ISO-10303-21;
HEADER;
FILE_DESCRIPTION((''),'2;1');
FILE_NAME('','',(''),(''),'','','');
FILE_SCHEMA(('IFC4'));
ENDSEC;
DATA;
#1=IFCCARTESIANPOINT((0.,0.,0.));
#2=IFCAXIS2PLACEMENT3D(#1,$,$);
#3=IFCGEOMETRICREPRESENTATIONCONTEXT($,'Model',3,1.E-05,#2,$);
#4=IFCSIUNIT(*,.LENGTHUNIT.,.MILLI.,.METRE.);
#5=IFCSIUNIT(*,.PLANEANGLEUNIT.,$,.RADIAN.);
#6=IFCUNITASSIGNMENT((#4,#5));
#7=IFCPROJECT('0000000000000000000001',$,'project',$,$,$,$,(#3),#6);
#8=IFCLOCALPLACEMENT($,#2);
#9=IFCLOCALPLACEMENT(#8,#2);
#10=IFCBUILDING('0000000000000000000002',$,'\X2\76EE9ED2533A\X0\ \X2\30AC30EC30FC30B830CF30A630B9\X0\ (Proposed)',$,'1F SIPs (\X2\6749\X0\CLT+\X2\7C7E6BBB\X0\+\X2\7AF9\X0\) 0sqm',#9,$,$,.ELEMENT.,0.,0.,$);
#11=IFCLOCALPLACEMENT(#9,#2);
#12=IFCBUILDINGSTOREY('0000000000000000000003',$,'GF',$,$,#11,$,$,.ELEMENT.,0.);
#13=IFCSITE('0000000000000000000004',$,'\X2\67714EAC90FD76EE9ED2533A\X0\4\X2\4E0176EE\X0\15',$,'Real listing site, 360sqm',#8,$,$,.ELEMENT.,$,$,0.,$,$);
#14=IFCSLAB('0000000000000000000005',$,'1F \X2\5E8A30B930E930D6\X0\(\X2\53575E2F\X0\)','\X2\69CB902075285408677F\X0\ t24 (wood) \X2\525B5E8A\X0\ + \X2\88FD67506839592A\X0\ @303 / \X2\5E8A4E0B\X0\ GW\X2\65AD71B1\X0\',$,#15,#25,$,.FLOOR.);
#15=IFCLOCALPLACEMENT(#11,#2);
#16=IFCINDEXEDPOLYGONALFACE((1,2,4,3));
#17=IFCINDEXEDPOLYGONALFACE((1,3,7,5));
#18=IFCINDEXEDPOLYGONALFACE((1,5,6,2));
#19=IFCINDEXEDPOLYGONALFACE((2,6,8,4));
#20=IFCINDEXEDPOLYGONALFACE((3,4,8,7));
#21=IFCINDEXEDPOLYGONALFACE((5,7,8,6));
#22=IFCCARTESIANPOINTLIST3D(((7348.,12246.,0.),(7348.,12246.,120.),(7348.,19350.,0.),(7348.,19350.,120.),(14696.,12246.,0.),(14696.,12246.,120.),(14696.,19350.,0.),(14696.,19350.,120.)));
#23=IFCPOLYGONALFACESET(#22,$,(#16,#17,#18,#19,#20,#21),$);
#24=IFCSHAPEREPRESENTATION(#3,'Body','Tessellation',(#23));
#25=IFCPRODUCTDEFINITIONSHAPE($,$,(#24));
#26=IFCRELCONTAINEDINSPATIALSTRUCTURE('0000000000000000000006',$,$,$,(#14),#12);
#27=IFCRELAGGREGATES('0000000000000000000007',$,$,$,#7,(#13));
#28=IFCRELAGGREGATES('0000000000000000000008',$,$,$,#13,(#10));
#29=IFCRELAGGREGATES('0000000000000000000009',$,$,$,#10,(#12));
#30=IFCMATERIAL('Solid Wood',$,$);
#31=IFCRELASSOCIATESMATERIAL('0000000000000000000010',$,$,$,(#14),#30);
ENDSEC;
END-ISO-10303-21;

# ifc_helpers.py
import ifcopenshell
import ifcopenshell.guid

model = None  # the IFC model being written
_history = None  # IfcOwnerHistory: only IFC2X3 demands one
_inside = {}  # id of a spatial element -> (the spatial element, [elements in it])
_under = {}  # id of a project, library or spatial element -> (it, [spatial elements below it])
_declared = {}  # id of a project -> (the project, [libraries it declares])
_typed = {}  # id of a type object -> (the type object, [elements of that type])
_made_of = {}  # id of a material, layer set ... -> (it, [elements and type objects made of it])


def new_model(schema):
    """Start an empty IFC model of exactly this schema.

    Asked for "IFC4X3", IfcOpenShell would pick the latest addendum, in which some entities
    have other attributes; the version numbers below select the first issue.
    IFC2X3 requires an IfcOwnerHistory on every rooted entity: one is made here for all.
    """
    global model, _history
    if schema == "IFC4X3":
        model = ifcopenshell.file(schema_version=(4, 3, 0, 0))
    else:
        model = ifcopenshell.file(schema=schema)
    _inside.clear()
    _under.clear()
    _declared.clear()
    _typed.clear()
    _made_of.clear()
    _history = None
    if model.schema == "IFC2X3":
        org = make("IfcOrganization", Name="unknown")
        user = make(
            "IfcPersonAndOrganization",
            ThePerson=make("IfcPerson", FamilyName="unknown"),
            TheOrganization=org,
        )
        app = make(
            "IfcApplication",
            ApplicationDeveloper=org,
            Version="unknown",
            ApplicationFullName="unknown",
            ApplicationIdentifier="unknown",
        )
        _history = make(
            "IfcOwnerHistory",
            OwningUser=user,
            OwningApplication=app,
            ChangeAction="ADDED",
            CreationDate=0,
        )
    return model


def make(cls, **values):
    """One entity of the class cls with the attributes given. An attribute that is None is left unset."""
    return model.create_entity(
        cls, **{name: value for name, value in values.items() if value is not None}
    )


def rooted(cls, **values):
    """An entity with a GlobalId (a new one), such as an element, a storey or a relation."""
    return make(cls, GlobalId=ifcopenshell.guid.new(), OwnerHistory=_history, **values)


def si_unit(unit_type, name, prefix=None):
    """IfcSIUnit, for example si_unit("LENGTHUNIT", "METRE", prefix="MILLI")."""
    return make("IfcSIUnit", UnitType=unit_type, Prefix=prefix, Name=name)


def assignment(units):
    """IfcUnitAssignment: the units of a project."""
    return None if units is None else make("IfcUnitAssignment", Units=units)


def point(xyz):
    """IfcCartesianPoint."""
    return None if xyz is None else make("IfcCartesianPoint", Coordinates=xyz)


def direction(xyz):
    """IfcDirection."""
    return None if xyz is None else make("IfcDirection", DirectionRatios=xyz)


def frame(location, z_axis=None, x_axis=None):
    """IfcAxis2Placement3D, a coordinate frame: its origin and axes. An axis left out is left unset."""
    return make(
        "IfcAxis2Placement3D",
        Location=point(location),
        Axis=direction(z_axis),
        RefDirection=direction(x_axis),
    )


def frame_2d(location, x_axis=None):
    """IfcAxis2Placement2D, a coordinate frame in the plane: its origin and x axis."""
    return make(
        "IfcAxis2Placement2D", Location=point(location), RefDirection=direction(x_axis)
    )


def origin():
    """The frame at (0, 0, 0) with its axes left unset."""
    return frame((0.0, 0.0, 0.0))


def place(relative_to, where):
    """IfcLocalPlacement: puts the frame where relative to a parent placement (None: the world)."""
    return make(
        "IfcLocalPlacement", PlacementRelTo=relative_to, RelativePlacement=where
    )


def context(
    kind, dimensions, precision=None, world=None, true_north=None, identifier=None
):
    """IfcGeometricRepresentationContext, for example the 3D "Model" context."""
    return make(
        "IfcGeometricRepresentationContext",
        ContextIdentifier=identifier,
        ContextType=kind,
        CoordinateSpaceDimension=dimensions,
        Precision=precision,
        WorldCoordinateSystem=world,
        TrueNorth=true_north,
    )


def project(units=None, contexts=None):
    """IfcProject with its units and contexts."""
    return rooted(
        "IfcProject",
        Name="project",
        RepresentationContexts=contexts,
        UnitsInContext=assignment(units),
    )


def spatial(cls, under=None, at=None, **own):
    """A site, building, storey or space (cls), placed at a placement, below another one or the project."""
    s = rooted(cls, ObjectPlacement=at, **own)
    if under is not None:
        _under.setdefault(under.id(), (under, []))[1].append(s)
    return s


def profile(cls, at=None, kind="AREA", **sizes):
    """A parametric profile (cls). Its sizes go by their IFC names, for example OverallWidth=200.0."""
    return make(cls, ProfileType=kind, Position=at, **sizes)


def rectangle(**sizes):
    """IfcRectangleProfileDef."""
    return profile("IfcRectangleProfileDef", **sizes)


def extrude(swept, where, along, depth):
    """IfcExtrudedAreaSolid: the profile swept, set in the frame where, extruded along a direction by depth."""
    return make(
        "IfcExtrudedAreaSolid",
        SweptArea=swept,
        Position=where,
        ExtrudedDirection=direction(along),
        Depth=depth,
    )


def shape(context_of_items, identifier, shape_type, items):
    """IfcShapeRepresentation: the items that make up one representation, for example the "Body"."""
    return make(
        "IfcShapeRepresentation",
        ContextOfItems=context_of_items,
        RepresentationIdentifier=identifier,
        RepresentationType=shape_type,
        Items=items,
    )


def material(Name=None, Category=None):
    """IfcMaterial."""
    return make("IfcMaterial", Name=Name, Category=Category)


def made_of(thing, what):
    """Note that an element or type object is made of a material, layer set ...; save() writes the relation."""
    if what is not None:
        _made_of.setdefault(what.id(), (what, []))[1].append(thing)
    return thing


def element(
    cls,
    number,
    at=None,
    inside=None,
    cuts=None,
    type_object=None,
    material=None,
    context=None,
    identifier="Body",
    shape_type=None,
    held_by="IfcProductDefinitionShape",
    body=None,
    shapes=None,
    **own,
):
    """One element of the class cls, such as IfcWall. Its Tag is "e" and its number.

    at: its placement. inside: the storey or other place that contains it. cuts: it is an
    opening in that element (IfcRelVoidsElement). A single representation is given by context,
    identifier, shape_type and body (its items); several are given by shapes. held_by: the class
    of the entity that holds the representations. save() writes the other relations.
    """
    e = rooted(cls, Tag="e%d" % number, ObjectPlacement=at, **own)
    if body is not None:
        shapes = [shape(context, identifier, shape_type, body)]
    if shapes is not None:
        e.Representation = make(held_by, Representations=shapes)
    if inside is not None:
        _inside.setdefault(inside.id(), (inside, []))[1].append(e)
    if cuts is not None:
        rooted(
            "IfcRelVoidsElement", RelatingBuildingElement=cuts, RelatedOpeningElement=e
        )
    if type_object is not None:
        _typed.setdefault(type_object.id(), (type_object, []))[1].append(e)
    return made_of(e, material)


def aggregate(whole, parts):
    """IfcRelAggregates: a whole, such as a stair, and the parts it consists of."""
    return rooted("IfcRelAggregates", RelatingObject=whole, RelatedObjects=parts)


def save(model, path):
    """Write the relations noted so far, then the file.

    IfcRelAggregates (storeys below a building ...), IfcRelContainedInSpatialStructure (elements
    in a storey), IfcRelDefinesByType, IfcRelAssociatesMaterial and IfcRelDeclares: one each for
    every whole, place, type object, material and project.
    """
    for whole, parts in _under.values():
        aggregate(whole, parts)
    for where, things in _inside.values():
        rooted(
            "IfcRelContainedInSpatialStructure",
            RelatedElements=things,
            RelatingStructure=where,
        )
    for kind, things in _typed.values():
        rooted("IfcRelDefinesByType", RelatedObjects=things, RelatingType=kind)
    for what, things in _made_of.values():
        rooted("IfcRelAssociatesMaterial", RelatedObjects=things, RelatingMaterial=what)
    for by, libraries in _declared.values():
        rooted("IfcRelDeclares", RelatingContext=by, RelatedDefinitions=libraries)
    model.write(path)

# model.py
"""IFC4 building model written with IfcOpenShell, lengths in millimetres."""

from ifc_helpers import new_model, si_unit, frame, frame_2d, origin, place, context, project, spatial, rectangle, extrude, material, element, save


model = new_model("IFC4")

# Units and contexts
model_context = context("Model", 3, precision=1e-05, world=origin())
ifc_project = project(units=[si_unit("LENGTHUNIT", "METRE", prefix="MILLI"), si_unit("PLANEANGLEUNIT", "RADIAN")], contexts=[model_context])

# Site, building, storey
site_placement = place(None, origin())
site = spatial("IfcSite", under=ifc_project, at=site_placement, Name="東京都目黒区4丁目15", ObjectType="Real listing site, 360sqm", CompositionType="ELEMENT", RefElevation=0.0)
building_placement = place(site_placement, origin())
building = spatial("IfcBuilding", under=site, at=building_placement, Name="目黒区 ガレージハウス (Proposed)", ObjectType="1F SIPs (杉CLT+籾殻+竹) 0sqm", CompositionType="ELEMENT", ElevationOfRefHeight=0.0, ElevationOfTerrain=0.0)
storey_placement = place(building_placement, origin())
storey = spatial("IfcBuildingStorey", under=building, at=storey_placement, Name="GF", CompositionType="ELEMENT", Elevation=0.0)

# Slab
ifc_material_1 = material(Name="Solid Wood")
slab_1_placement = place(storey_placement, frame((3674.0, 6123.0, 0.0)))
element("IfcSlab", 1, at=slab_1_placement, inside=storey, material=ifc_material_1, Name="1F 床スラブ(南帯)", Description="構造用合板 t24 (wood) 剛床 + 製材根太 @303 / 床下 GW断熱", PredefinedType="FLOOR", context=model_context, shape_type="SweptSolid", body=[
    extrude(rectangle(XDim=7348.0, YDim=7104.0, at=frame_2d((3674.0, 3552.0))), frame((3674.0, 6123.0, 0.0)), (0.0, 0.0, 1.0), 120.0),
])

save(model, "model.ifc")
